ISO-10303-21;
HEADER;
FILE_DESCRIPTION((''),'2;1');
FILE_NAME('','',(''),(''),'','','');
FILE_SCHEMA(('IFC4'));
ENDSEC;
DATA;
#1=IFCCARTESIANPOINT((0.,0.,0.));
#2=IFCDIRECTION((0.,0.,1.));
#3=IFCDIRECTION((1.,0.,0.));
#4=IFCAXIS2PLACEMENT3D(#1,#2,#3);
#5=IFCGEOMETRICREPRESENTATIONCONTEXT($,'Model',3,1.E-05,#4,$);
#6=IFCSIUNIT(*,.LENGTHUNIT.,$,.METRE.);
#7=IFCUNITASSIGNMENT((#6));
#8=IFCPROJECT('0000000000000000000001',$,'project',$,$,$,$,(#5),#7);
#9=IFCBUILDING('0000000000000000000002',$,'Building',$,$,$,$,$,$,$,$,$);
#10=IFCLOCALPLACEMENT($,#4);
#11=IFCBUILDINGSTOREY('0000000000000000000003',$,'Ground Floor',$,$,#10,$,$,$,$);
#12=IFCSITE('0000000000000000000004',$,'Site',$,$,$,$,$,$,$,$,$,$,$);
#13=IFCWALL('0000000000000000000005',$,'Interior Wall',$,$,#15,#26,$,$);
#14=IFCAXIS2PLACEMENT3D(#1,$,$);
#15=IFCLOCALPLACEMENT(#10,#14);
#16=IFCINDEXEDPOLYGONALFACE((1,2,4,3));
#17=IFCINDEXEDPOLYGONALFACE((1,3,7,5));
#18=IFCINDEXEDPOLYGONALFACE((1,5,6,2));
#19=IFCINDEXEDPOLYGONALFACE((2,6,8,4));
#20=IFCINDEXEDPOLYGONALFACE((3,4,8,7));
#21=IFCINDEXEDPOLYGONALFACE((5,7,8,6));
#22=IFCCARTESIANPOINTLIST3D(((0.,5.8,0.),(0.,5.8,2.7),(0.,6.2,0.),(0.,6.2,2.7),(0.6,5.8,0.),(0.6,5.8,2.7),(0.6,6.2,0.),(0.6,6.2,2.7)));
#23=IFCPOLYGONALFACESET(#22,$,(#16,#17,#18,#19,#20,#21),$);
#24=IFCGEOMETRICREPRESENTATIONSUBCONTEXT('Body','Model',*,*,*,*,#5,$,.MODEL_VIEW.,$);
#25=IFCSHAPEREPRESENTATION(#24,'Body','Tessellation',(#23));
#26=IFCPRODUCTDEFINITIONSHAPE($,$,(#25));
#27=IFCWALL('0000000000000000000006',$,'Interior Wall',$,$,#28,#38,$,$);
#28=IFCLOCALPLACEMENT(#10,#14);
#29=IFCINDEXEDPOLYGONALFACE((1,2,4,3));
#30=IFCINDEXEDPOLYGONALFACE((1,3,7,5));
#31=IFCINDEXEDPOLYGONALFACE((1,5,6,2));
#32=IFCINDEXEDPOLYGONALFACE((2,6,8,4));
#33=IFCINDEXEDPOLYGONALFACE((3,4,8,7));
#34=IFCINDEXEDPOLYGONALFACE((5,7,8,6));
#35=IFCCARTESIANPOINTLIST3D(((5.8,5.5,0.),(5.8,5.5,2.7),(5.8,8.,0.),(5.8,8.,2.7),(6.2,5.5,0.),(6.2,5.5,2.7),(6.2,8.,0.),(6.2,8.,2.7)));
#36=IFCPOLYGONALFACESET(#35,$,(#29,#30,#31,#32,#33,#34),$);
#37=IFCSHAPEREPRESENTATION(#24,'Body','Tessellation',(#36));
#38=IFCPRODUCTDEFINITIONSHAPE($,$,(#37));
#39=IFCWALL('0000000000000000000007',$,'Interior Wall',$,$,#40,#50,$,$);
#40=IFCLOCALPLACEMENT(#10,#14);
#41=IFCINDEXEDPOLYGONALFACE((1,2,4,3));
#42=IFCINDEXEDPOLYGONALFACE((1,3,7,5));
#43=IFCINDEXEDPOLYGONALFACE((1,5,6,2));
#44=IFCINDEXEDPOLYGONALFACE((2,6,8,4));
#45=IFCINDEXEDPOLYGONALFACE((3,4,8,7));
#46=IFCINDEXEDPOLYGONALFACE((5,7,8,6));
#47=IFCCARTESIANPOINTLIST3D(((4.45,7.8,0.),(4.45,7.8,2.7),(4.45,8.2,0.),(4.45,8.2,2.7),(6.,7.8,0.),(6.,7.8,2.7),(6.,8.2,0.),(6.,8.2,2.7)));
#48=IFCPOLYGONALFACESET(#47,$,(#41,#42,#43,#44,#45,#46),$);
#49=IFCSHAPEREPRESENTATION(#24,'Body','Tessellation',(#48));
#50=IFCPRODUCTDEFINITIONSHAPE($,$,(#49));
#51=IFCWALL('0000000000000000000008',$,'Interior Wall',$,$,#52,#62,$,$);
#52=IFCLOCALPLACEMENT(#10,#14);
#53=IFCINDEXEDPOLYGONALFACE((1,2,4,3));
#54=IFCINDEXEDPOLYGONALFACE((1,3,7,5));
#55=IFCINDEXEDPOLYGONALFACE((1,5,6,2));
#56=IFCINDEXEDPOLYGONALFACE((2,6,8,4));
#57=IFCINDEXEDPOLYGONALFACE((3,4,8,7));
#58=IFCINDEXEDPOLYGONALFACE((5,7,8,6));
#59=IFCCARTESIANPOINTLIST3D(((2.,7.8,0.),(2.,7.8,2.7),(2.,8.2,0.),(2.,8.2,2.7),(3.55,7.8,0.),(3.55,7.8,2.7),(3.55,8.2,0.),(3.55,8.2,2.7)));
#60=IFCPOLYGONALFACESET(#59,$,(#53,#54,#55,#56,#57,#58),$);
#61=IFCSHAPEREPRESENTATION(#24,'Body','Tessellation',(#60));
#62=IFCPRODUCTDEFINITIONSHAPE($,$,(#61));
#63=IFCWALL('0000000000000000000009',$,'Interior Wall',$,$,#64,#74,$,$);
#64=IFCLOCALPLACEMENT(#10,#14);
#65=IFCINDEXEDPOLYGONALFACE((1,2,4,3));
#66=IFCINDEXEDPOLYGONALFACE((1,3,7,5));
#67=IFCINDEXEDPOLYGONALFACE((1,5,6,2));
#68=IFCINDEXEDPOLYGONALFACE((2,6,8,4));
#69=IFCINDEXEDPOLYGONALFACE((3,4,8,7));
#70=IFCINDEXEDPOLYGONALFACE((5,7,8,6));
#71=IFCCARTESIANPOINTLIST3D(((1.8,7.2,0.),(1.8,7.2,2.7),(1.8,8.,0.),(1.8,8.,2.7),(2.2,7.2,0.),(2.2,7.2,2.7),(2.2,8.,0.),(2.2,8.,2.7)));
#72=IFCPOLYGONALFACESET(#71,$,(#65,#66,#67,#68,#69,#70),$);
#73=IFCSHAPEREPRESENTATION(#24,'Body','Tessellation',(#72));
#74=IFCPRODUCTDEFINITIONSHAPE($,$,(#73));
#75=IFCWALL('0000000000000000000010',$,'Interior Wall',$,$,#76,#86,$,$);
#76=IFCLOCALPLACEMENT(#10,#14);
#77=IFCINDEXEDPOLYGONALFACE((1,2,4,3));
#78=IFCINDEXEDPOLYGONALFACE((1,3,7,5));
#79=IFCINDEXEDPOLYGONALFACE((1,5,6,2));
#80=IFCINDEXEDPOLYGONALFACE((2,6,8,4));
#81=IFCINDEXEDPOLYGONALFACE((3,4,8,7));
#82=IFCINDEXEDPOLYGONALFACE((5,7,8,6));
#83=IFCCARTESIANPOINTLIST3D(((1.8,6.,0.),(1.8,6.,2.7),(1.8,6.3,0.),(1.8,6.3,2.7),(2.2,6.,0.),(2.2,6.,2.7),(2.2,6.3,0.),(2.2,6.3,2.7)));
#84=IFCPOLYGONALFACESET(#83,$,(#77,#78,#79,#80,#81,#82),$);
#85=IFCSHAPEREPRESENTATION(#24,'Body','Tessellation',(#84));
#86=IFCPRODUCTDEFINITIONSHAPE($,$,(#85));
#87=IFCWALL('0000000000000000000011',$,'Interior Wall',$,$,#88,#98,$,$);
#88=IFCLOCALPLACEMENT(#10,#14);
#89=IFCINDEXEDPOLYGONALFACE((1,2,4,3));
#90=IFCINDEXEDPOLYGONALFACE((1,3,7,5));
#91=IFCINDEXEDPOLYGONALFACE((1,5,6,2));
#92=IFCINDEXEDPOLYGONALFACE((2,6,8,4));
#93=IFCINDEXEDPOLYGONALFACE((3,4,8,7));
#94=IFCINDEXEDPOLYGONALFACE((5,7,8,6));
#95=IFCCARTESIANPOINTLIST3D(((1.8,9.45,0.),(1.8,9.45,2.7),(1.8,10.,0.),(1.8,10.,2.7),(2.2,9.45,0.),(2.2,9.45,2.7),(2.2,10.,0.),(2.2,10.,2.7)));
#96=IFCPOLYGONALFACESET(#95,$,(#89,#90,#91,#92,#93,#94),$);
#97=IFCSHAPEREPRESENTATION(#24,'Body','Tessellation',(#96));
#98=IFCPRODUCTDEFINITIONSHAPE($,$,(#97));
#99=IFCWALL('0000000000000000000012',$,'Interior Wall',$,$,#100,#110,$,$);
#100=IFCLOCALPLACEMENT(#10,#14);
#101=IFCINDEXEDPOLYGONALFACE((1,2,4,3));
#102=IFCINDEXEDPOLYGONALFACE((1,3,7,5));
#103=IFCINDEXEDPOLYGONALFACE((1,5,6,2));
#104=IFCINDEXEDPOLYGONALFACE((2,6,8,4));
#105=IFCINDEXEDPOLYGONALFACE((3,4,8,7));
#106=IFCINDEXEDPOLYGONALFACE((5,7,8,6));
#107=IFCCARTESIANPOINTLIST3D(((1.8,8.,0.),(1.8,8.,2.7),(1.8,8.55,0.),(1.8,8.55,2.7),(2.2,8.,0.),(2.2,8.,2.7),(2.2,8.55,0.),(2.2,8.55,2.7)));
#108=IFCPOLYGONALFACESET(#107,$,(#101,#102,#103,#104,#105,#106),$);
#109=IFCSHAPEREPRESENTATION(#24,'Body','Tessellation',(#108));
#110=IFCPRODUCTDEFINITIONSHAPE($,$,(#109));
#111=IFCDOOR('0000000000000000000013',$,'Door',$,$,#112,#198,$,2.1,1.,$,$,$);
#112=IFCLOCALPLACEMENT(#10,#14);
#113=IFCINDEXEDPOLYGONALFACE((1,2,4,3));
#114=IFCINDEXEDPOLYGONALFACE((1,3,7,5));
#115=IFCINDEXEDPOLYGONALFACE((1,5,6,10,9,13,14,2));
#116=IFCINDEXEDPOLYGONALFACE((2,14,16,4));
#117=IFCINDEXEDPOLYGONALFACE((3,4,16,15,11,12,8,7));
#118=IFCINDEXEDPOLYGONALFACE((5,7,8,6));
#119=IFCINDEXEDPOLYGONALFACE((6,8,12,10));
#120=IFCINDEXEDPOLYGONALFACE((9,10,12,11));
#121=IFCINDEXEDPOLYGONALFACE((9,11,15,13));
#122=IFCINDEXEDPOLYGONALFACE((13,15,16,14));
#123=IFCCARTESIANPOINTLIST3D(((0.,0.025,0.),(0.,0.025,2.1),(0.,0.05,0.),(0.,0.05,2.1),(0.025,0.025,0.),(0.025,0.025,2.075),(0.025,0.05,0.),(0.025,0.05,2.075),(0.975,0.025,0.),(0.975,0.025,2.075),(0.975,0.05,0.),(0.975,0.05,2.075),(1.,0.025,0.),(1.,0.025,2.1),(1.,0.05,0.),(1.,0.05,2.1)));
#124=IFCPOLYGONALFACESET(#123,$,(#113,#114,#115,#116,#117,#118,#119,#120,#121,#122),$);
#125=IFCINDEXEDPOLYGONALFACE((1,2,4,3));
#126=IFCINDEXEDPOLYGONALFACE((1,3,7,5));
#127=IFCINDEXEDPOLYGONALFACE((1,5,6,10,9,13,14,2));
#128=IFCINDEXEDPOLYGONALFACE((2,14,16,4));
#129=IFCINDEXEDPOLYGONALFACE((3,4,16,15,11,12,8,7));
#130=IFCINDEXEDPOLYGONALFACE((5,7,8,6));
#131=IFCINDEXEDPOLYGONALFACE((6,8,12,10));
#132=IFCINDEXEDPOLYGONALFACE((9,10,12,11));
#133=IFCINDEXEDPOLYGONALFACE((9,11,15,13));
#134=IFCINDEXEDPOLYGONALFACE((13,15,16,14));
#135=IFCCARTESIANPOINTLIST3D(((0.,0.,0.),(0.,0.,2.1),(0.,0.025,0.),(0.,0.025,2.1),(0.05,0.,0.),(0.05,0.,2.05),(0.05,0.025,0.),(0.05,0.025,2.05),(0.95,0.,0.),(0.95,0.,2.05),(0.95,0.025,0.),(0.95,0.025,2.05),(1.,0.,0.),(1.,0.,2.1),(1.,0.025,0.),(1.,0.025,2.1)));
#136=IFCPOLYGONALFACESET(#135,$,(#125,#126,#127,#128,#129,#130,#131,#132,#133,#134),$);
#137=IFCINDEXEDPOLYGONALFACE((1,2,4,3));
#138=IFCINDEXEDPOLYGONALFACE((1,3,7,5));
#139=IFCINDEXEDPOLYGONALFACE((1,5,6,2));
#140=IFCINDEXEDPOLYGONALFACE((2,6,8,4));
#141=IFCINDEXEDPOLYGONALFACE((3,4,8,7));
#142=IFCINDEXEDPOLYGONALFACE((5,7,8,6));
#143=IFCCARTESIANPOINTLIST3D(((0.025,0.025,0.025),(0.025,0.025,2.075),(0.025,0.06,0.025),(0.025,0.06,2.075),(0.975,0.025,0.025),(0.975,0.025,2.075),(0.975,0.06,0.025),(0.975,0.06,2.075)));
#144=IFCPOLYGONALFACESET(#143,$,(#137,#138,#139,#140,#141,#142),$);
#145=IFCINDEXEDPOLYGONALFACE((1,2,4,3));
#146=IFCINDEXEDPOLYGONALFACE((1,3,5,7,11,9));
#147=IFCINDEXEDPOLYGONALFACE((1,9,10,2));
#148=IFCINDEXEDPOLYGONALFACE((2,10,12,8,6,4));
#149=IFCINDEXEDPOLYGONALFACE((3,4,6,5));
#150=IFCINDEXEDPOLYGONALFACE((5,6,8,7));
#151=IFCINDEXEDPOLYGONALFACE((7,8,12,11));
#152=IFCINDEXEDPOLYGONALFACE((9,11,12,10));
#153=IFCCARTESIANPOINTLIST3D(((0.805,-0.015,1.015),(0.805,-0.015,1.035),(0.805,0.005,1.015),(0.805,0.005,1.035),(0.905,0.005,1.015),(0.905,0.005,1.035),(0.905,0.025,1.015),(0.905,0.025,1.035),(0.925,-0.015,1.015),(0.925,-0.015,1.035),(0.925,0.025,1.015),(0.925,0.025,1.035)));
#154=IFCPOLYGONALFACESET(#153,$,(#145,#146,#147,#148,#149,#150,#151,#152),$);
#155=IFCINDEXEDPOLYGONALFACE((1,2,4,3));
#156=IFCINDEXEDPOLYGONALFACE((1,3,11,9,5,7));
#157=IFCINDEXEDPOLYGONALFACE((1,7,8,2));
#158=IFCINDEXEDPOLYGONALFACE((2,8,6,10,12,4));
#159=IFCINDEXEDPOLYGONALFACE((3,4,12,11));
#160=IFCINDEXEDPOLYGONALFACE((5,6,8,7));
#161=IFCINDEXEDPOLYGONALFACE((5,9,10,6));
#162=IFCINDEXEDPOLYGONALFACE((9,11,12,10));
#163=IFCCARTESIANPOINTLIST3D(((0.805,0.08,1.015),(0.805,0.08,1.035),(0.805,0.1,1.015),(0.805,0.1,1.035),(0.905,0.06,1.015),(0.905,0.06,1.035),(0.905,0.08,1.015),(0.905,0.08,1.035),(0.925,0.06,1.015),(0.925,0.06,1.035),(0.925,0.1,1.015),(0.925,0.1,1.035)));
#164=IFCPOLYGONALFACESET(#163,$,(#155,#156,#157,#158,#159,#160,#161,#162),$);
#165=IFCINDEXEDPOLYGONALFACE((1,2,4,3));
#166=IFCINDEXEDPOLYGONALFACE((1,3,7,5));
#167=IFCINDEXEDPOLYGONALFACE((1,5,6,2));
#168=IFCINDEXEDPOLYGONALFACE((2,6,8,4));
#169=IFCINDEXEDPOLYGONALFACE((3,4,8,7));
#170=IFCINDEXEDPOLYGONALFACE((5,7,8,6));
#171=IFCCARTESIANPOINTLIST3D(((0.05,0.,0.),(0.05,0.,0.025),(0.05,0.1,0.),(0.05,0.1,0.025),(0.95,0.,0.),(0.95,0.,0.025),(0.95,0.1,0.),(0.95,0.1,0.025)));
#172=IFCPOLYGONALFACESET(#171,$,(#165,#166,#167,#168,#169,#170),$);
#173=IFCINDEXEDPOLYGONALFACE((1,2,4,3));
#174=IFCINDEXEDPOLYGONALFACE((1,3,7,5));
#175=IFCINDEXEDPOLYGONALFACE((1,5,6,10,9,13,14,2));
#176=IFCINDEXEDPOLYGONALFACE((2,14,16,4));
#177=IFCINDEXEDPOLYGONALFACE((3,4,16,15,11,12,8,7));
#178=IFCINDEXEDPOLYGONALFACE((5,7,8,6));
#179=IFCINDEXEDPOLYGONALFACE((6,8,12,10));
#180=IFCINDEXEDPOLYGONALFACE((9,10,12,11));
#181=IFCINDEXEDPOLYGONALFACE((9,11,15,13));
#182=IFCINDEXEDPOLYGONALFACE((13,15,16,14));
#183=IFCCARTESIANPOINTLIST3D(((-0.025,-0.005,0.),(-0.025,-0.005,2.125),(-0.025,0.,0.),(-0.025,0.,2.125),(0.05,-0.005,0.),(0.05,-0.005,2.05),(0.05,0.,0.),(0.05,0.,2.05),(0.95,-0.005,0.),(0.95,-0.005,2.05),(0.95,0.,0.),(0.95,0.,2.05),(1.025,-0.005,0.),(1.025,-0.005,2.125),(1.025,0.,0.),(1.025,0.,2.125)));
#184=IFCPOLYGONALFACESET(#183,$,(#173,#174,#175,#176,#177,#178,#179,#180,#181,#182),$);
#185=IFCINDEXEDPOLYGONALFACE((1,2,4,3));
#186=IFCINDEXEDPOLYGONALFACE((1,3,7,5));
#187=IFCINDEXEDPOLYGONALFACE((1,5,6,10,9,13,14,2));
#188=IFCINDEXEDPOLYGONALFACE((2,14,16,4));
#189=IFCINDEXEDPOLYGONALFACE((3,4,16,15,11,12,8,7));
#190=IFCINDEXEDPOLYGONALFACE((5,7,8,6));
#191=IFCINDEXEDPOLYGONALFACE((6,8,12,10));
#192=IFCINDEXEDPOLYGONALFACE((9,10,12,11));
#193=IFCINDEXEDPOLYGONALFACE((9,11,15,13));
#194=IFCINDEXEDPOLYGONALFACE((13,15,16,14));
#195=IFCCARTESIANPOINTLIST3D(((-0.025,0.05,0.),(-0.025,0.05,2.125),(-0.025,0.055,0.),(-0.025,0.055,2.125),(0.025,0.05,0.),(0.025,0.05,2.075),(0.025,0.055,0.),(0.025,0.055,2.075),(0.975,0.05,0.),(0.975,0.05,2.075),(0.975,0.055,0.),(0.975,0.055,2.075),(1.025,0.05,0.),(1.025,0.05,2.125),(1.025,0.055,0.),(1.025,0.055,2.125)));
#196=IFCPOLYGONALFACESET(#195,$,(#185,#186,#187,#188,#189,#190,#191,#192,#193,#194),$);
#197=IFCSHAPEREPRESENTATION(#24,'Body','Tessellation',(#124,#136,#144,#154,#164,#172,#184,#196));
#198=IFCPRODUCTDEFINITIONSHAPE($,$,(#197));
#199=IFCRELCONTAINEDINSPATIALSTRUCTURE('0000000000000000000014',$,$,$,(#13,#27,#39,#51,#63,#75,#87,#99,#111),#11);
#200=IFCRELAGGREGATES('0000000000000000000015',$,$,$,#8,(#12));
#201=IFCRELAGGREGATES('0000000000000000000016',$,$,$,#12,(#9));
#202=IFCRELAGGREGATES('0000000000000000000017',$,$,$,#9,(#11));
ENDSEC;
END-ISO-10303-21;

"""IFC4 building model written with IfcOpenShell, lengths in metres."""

from ifc_helpers import new_model, si_unit, frame, origin_with_axes, place, context, subcontext, project, spatial, line, indexed_curve, outline, extrude, element, save


model = new_model("IFC4")

# Units and contexts
model_context = context("Model", 3, precision=1e-05, world=origin_with_axes())
body_context = subcontext(model_context, "Body", "Model", "MODEL_VIEW")
ifc_project = project(units=[si_unit("LENGTHUNIT", "METRE")], contexts=[model_context])

# Site, building, storey
site = spatial("IfcSite", under=ifc_project, Name="Site")
building = spatial("IfcBuilding", under=site, Name="Building")
storey_placement = place(None, origin_with_axes())
storey = spatial("IfcBuildingStorey", under=building, at=storey_placement, Name="Ground Floor")

# Walls
for number, where, z_axis, x_axis, name in (
    (1, (0.6, 6.0, 0.0), (0.0, 0.0, 1.0), (-1.0, 0.0, 0.0), "Interior Wall"),
):
    element("IfcWall", number, at=place(storey_placement, frame(where, z_axis=z_axis, x_axis=x_axis)), inside=storey, Name=name, context=body_context, shape_type="SweptSolid", body=[
        extrude(outline(indexed_curve([(0.0, 0.0), (0.0, 0.4), (0.6, 0.4), (0.6, 0.0), (0.0, 0.0)], self_intersect=False)), frame((0.0, -0.2, 0.0), z_axis=(0.0, 0.0, 1.0), x_axis=(1.0, 0.0, 0.0)), (0.0, 0.0, 1.0), 2.7),
    ])
wall_1_placement = place(storey_placement, frame((6.0, 5.5, 0.0), z_axis=(0.0, 0.0, 1.0), x_axis=(0.0, 1.0, 0.0)))
element("IfcWall", 2, at=wall_1_placement, inside=storey, Name="Interior Wall", context=body_context, shape_type="SweptSolid", body=[
    extrude(outline(indexed_curve([(0.0, 0.0), (0.0, 0.4), (2.5, 0.4), (2.5, 0.0), (0.0, 0.0)], self_intersect=False)), frame((0.0, -0.2, 0.0), z_axis=(0.0, 0.0, 1.0), x_axis=(1.0, 0.0, 0.0)), (0.0, 0.0, 1.0), 2.7),
])
for number, where, z_axis, x_axis, name in (
    (3, (6.0, 8.0, 0.0), (0.0, 0.0, 1.0), (-1.0, 0.0, 0.0), "Interior Wall"),
    (4, (3.55, 8.0, 0.0), (0.0, 0.0, 1.0), (-1.0, 0.0, 0.0), "Interior Wall"),
):
    element("IfcWall", number, at=place(storey_placement, frame(where, z_axis=z_axis, x_axis=x_axis)), inside=storey, Name=name, context=body_context, shape_type="SweptSolid", body=[
        extrude(outline(indexed_curve([(0.0, 0.0), (0.0, 0.4), (1.55, 0.4), (1.55, 0.0), (0.0, 0.0)], self_intersect=False)), frame((0.0, -0.2, 0.0), z_axis=(0.0, 0.0, 1.0), x_axis=(1.0, 0.0, 0.0)), (0.0, 0.0, 1.0), 2.7),
    ])
wall_2_placement = place(storey_placement, frame((2.0, 8.0, 0.0), z_axis=(0.0, 0.0, 1.0), x_axis=(0.0, -1.0, 0.0)))
element("IfcWall", 5, at=wall_2_placement, inside=storey, Name="Interior Wall", context=body_context, shape_type="SweptSolid", body=[
    extrude(outline(indexed_curve([(0.0, 0.0), (0.0, 0.4), (0.8, 0.4), (0.8, 0.0), (0.0, 0.0)], self_intersect=False)), frame((0.0, -0.2, 0.0), z_axis=(0.0, 0.0, 1.0), x_axis=(1.0, 0.0, 0.0)), (0.0, 0.0, 1.0), 2.7),
])
wall_3_placement = place(storey_placement, frame((2.0, 6.3, 0.0), z_axis=(0.0, 0.0, 1.0), x_axis=(0.0, -1.0, 0.0)))
element("IfcWall", 6, at=wall_3_placement, inside=storey, Name="Interior Wall", context=body_context, shape_type="SweptSolid", body=[
    extrude(outline(indexed_curve([(0.0, 0.0), (0.0, 0.4), (0.3, 0.4), (0.3, 0.0), (0.0, 0.0)], self_intersect=False)), frame((0.0, -0.2, 0.0), z_axis=(0.0, 0.0, 1.0), x_axis=(1.0, 0.0, 0.0)), (0.0, 0.0, 1.0), 2.7),
])
for number, where, z_axis, x_axis, name in (
    (7, (2.0, 10.0, 0.0), (0.0, 0.0, 1.0), (0.0, -1.0, 0.0), "Interior Wall"),
    (8, (2.0, 8.55, 0.0), (0.0, 0.0, 1.0), (0.0, -1.0, 0.0), "Interior Wall"),
):
    element("IfcWall", number, at=place(storey_placement, frame(where, z_axis=z_axis, x_axis=x_axis)), inside=storey, Name=name, context=body_context, shape_type="SweptSolid", body=[
        extrude(outline(indexed_curve([(0.0, 0.0), (0.0, 0.4), (0.55, 0.4), (0.55, 0.0), (0.0, 0.0)], self_intersect=False)), frame((0.0, -0.2, 0.0), z_axis=(0.0, 0.0, 1.0), x_axis=(1.0, 0.0, 0.0)), (0.0, 0.0, 1.0), 2.7),
    ])

# Door
door_1_placement = place(storey_placement, origin_with_axes())
element("IfcDoor", 9, at=door_1_placement, inside=storey, Name="Door", OverallHeight=2.1, OverallWidth=1.0, context=body_context, shape_type="SweptSolid", body=[
    extrude(outline(indexed_curve([(0.0, 0.0), (0.0, 2.1), (1.0, 2.1), (1.0, 0.0), (0.975, 0.0), (0.975, 2.075), (0.025, 2.075), (0.025, 0.0)], segments=[line(1, 2, 3, 4, 5, 6, 7, 8, 1)])), frame((0.0, 0.025, 0.0), z_axis=(0.0, -1.0, 0.0), x_axis=(1.0, 0.0, 0.0)), (0.0, 0.0, -1.0), 0.025),
    extrude(outline(indexed_curve([(0.0, 0.0), (0.0, 2.1), (1.0, 2.1), (1.0, 0.0), (0.95, 0.0), (0.95, 2.05), (0.05, 2.05), (0.05, 0.0)], segments=[line(1, 2, 3, 4, 5, 6, 7, 8, 1)])), frame((0.0, 0.0, 0.0), z_axis=(0.0, -1.0, 0.0), x_axis=(1.0, 0.0, 0.0)), (0.0, 0.0, -1.0), 0.025),
    extrude(outline(indexed_curve([(0.0, 0.0), (0.95, 0.0), (0.95, 0.035), (0.0, 0.035)], segments=[line(1, 2, 3, 4, 1)])), frame((0.025, 0.025, 0.025), z_axis=(0.0, 0.0, 1.0), x_axis=(1.0, 0.0, 0.0)), (0.0, 0.0, 1.0), 2.05),
    extrude(outline(indexed_curve([(0.0, 0.0), (0.0, -0.04), (-0.12, -0.04), (-0.12, -0.02), (-0.02, -0.02), (-0.02, 0.0)], segments=[line(1, 2, 3, 4, 5, 6, 1)])), frame((0.925, 0.025, 1.015), z_axis=(0.0, 0.0, 1.0), x_axis=(1.0, 0.0, 0.0)), (0.0, 0.0, 1.0), 0.02),
    extrude(outline(indexed_curve([(0.0, 0.0), (0.0, 0.04), (-0.12, 0.04), (-0.12, 0.02), (-0.02, 0.02), (-0.02, 0.0)], segments=[line(1, 2, 3, 4, 5, 6, 1)])), frame((0.925, 0.06, 1.015), z_axis=(0.0, 0.0, 1.0), x_axis=(1.0, 0.0, 0.0)), (0.0, 0.0, 1.0), 0.02),
    extrude(outline(indexed_curve([(0.0, 0.0), (0.9, 0.0), (0.9, 0.1), (0.0, 0.1)], segments=[line(1, 2, 3, 4, 1)])), frame((0.05, 0.0, 0.0), z_axis=(0.0, 0.0, 1.0), x_axis=(1.0, 0.0, 0.0)), (0.0, 0.0, 1.0), 0.025),
    extrude(outline(indexed_curve([(0.0, 0.0), (0.0, 2.125), (1.05, 2.125), (1.05, 0.0), (0.975, 0.0), (0.975, 2.05), (0.075, 2.05), (0.075, 0.0)], segments=[line(1, 2, 3, 4, 5, 6, 7, 8, 1)])), frame((-0.025, -0.005, 0.0), z_axis=(0.0, -1.0, 0.0), x_axis=(1.0, 0.0, 0.0)), (0.0, 0.0, -1.0), 0.005),
    extrude(outline(indexed_curve([(0.0, 0.0), (0.0, 2.125), (1.05, 2.125), (1.05, 0.0), (1.0, 0.0), (1.0, 2.075), (0.05, 2.075), (0.05, 0.0)], segments=[line(1, 2, 3, 4, 5, 6, 7, 8, 1)])), frame((-0.025, 0.05, 0.0), z_axis=(0.0, -1.0, 0.0), x_axis=(1.0, 0.0, 0.0)), (0.0, 0.0, -1.0), 0.005),
])

save(model, "model.ifc")
